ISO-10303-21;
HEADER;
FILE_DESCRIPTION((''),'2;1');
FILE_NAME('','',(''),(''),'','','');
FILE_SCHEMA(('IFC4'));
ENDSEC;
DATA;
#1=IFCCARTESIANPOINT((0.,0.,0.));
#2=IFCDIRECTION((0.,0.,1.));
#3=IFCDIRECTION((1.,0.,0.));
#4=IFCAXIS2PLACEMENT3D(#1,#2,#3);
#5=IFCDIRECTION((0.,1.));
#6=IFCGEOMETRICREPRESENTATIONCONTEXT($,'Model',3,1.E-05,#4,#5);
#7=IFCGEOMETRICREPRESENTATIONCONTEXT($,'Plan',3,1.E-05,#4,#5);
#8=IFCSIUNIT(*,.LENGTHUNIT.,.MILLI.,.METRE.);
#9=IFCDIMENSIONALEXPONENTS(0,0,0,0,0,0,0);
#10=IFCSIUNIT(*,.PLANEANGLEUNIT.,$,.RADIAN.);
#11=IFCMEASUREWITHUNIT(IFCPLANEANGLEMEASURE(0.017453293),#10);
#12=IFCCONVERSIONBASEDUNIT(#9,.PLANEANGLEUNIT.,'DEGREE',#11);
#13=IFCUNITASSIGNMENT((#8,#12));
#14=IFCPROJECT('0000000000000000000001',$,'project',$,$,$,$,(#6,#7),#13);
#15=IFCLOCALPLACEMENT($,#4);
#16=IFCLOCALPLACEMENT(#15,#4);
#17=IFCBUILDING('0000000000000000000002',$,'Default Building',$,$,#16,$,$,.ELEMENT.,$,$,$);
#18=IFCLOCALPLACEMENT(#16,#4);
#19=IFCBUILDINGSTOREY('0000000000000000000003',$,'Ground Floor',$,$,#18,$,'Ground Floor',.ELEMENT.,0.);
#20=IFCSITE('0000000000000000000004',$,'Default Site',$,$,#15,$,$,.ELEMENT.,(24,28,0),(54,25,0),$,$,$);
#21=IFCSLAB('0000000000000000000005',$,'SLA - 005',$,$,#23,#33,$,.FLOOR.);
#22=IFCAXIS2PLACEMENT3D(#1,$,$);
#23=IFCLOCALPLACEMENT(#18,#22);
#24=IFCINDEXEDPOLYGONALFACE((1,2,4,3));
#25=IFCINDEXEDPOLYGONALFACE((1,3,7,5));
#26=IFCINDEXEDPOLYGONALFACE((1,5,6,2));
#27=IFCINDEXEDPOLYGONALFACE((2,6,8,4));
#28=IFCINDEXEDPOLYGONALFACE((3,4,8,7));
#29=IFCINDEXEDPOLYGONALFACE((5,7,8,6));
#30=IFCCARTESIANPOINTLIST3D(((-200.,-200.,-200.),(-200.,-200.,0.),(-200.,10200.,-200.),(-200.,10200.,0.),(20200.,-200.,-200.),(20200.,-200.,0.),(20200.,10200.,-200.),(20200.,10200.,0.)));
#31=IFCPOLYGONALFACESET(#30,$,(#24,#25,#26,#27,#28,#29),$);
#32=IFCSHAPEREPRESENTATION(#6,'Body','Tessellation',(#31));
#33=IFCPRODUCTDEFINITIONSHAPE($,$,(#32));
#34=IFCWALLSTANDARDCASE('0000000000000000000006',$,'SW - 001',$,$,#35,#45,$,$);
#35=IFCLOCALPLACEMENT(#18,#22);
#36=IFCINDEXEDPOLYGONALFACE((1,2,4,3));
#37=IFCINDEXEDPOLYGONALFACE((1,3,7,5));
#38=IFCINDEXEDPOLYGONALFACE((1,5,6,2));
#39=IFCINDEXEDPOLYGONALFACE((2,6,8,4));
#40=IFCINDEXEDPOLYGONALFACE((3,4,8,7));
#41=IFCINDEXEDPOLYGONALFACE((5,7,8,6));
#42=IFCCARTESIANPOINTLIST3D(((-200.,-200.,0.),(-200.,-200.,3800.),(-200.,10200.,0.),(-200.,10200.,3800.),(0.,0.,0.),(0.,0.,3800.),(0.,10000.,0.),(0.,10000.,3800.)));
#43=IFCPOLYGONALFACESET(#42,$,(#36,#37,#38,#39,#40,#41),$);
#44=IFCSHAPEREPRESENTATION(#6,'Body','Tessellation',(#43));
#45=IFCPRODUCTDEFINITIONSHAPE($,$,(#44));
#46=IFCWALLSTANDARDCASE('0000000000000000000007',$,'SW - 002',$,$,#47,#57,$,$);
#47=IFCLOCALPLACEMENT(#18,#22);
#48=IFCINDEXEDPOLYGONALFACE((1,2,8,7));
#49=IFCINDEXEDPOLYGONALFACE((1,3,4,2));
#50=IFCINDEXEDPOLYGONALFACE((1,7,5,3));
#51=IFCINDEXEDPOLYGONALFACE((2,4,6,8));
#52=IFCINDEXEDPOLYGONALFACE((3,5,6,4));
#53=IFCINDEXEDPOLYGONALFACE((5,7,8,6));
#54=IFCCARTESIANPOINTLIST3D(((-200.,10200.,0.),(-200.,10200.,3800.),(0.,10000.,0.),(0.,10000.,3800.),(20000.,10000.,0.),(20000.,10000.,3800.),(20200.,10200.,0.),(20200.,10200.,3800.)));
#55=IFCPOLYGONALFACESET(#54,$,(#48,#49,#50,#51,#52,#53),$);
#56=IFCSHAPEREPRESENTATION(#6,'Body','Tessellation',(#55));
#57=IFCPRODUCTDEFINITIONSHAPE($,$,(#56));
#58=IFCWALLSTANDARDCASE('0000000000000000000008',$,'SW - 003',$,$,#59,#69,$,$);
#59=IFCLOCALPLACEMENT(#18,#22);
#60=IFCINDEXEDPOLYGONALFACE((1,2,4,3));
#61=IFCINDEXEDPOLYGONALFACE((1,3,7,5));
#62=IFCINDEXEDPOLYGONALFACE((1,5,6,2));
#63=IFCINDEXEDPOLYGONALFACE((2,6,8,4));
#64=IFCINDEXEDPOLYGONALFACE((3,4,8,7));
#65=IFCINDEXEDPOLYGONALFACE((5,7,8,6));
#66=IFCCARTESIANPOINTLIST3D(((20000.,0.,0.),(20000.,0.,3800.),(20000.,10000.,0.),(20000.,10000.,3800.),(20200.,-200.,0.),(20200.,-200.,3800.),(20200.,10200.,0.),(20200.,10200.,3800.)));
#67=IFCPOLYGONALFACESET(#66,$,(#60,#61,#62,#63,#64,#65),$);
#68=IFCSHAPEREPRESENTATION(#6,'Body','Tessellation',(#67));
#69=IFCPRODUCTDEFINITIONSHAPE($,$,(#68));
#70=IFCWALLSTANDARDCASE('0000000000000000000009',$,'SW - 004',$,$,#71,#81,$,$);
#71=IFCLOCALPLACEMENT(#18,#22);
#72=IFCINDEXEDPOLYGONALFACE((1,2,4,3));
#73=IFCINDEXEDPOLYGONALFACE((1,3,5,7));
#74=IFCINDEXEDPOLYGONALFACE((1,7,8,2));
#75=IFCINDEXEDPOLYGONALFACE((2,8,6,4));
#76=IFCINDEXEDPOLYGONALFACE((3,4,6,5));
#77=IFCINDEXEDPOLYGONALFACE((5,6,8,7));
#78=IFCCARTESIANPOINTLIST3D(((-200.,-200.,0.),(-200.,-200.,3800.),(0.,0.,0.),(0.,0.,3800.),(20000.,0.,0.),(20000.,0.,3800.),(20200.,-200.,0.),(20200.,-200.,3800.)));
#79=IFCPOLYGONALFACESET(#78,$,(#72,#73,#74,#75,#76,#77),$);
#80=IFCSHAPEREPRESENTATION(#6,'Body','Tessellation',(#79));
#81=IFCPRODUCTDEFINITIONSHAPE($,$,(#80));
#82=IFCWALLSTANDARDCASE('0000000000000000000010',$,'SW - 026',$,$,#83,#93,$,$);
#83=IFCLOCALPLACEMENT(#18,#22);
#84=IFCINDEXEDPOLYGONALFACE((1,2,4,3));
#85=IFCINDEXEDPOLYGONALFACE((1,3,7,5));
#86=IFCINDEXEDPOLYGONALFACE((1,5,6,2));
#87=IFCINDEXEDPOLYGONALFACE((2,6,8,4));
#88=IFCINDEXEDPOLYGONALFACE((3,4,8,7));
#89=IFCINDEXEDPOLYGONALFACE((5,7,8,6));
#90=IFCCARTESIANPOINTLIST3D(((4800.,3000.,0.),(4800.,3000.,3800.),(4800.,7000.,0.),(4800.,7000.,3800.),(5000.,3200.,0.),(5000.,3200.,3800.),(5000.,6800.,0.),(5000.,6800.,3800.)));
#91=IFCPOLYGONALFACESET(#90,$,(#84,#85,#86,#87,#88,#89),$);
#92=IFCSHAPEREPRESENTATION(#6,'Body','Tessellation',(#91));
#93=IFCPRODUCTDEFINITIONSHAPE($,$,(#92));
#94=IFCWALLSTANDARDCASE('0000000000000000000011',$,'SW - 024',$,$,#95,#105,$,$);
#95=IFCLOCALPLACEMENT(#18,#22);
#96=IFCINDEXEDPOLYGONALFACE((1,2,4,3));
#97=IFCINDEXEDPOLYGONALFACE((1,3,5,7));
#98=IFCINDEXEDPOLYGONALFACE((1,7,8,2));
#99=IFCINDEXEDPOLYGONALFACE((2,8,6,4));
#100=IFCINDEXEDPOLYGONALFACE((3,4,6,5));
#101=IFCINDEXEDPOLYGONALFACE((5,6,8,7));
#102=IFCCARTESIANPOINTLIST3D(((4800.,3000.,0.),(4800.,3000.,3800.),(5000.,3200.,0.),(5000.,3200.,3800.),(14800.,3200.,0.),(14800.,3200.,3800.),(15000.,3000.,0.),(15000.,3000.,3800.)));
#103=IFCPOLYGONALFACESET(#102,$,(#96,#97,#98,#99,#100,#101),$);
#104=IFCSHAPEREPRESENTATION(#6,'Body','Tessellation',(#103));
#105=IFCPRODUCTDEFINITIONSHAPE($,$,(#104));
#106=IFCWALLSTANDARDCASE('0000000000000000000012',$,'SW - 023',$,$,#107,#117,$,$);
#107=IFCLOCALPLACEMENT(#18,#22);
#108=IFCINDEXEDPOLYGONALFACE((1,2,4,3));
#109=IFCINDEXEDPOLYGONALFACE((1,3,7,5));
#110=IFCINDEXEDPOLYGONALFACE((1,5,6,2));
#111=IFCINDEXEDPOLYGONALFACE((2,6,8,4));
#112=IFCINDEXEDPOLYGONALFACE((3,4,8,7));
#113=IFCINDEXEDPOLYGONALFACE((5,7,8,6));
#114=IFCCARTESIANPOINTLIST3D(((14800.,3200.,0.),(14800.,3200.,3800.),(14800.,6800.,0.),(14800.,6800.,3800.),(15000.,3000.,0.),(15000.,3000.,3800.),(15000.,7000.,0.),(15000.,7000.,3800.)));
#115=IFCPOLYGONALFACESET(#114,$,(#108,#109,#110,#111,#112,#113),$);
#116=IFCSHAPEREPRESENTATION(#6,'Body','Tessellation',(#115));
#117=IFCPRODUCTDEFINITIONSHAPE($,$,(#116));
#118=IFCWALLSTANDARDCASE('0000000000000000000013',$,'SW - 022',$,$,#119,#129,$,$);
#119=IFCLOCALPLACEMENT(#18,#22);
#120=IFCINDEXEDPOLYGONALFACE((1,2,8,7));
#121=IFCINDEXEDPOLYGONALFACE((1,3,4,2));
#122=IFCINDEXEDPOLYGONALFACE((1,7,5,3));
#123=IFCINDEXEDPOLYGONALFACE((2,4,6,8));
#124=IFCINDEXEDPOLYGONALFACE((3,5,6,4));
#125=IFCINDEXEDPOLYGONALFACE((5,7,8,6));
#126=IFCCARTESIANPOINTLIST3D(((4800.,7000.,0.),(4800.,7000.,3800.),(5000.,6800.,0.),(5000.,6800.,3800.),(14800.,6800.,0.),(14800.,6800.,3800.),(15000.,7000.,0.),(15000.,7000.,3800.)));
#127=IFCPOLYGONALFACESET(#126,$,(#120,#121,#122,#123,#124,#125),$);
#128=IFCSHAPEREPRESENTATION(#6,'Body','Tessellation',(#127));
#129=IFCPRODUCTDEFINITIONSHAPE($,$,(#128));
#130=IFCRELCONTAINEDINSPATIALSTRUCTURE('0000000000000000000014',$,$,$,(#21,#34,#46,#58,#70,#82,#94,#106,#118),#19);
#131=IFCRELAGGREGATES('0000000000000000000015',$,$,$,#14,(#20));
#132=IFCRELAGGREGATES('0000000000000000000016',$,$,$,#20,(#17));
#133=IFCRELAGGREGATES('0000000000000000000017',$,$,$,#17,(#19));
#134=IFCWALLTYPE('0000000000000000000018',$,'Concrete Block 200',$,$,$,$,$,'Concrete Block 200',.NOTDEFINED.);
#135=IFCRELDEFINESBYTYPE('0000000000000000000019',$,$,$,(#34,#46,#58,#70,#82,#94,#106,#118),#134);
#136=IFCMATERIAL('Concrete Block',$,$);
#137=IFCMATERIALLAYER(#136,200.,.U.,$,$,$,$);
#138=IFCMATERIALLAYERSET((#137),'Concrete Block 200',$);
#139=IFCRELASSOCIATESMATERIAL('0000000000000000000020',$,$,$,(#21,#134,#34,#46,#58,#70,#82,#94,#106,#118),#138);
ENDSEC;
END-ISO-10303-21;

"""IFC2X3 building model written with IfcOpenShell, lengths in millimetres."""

from ifc_helpers import new_model, entity, si_unit, converted_unit, direction, frame, origin_with_axes, place, context, project, spatial, polyline, outline, extrude, material, layer, layer_set, layer_usage, type_object, element, save


model = new_model("IFC2X3")

# Units and contexts
model_context = context("Model", 3, precision=1e-05, world=origin_with_axes(), true_north=direction((0.0, 1.0)))
plan_context = context("Plan", 3, precision=1e-05, world=origin_with_axes(), true_north=direction((0.0, 1.0)))
ifc_project = project(units=[si_unit("LENGTHUNIT", "METRE", prefix="MILLI"), converted_unit("PLANEANGLEUNIT", "DEGREE", entity("IfcPlaneAngleMeasure", 0.017453293), si_unit("PLANEANGLEUNIT", "RADIAN"), dimensions=[0, 0, 0, 0, 0, 0, 0])], contexts=[model_context, plan_context])

# Site, building, storey
site_placement = place(None, origin_with_axes())
site = spatial("IfcSite", under=ifc_project, at=site_placement, Name="Default Site", CompositionType="ELEMENT", RefLatitude=(24, 28, 0), RefLongitude=(54, 25, 0))
building_placement = place(site_placement, origin_with_axes())
building = spatial("IfcBuilding", under=site, at=building_placement, Name="Default Building", CompositionType="ELEMENT")
storey_placement = place(building_placement, origin_with_axes())
storey = spatial("IfcBuildingStorey", under=building, at=storey_placement, Name="Ground Floor", LongName="Ground Floor", CompositionType="ELEMENT", Elevation=0.0)

# Slab
ifc_material = material(Name="Concrete Block")
ifc_layer = layer(ifc_material, 200.0, ventilated="UNKNOWN")
ifc_layer_set = layer_set([ifc_layer], Name="Concrete Block 200")
ifc_layer_usage_1 = layer_usage(ifc_layer_set, "AXIS3", "NEGATIVE", 200.0)
slab_placement = place(storey_placement, frame((-200.0, 10200.0, -200.0), z_axis=(0.0, 0.0, 1.0), x_axis=(1.0, 0.0, 0.0)))
element("IfcSlab", 1, at=slab_placement, inside=storey, material=ifc_layer_usage_1, Name="SLA - 005", PredefinedType="FLOOR", context=model_context, shape_type="SweptSolid", body=[
    extrude(outline(polyline([(0.0, 0.0), (20400.0, 0.0), (20400.0, -10400.0), (0.0, -10400.0), (0.0, 0.0)])), origin_with_axes(), (0.0, 0.0, 1.0), 200.0),
])

# Walls
ifc_layer_usage_2 = layer_usage(ifc_layer_set, "AXIS2", "POSITIVE", 0.0)
wall_type = type_object("IfcWallType", Name="Concrete Block 200", ElementType="Concrete Block 200", PredefinedType="NOTDEFINED", material=ifc_layer_set)
wall_1_placement = place(storey_placement, frame((0.0, 0.0, 0.0), z_axis=(0.0, 0.0, 1.0), x_axis=(0.0, 1.0, 0.0)))
element("IfcWallStandardCase", 2, at=wall_1_placement, inside=storey, type_object=wall_type, material=ifc_layer_usage_2, Name="SW - 001", context=model_context, shape_type="SweptSolid", body=[
    extrude(outline(polyline([(0.0, 0.0), (10000.0, 0.0), (10200.0, 200.0), (-200.0, 200.0), (0.0, 0.0)])), origin_with_axes(), (0.0, 0.0, 1.0), 3800.0),
])
ifc_layer_usage_3 = layer_usage(ifc_layer_set, "AXIS2", "POSITIVE", 0.0)
wall_2_placement = place(storey_placement, frame((0.0, 10000.0, 0.0), z_axis=(0.0, 0.0, 1.0), x_axis=(1.0, 0.0, 0.0)))
element("IfcWallStandardCase", 3, at=wall_2_placement, inside=storey, type_object=wall_type, material=ifc_layer_usage_3, Name="SW - 002", context=model_context, shape_type="SweptSolid", body=[
    extrude(outline(polyline([(0.0, 0.0), (20000.0, 0.0), (20200.0, 200.0), (-200.0, 200.0), (0.0, 0.0)])), origin_with_axes(), (0.0, 0.0, 1.0), 3800.0),
])
ifc_layer_usage_4 = layer_usage(ifc_layer_set, "AXIS2", "POSITIVE", 0.0)
wall_3_placement = place(storey_placement, frame((20000.0, 10000.0, 0.0), z_axis=(0.0, 0.0, 1.0), x_axis=(0.0, -1.0, 0.0)))
element("IfcWallStandardCase", 4, at=wall_3_placement, inside=storey, type_object=wall_type, material=ifc_layer_usage_4, Name="SW - 003", context=model_context, shape_type="SweptSolid", body=[
    extrude(outline(polyline([(0.0, 0.0), (10000.0, 0.0), (10200.0, 200.0), (-200.0, 200.0), (0.0, 0.0)])), origin_with_axes(), (0.0, 0.0, 1.0), 3800.0),
])
ifc_layer_usage_5 = layer_usage(ifc_layer_set, "AXIS2", "POSITIVE", 0.0)
wall_4_placement = place(storey_placement, frame((20000.0, 0.0, 0.0), z_axis=(0.0, 0.0, 1.0), x_axis=(-1.0, 0.0, 0.0)))
element("IfcWallStandardCase", 5, at=wall_4_placement, inside=storey, type_object=wall_type, material=ifc_layer_usage_5, Name="SW - 004", context=model_context, shape_type="SweptSolid", body=[
    extrude(outline(polyline([(0.0, 0.0), (20000.0, 0.0), (20200.0, 200.0), (-200.0, 200.0), (0.0, 0.0)])), origin_with_axes(), (0.0, 0.0, 1.0), 3800.0),
])
ifc_layer_usage_6 = layer_usage(ifc_layer_set, "AXIS2", "NEGATIVE", 0.0)
wall_5_placement = place(storey_placement, frame((5000.0, 6800.0, 0.0), z_axis=(0.0, 0.0, 1.0), x_axis=(0.0, -1.0, 0.0)))
element("IfcWallStandardCase", 6, at=wall_5_placement, inside=storey, type_object=wall_type, material=ifc_layer_usage_6, Name="SW - 026", context=model_context, shape_type="SweptSolid", body=[
    extrude(outline(polyline([(-200.0, -200.0), (3800.0, -200.0), (3600.0, 0.0), (0.0, 0.0), (-200.0, -200.0)])), origin_with_axes(), (0.0, 0.0, 1.0), 3800.0),
])
ifc_layer_usage_7 = layer_usage(ifc_layer_set, "AXIS2", "POSITIVE", 0.0)
wall_6_placement = place(storey_placement, frame((14800.0, 3200.0, 0.0), z_axis=(0.0, 0.0, 1.0), x_axis=(-1.0, 0.0, 0.0)))
element("IfcWallStandardCase", 7, at=wall_6_placement, inside=storey, type_object=wall_type, material=ifc_layer_usage_7, Name="SW - 024", context=model_context, shape_type="SweptSolid", body=[
    extrude(outline(polyline([(0.0, 0.0), (9800.0, 0.0), (10000.0, 200.0), (-200.0, 200.0), (0.0, 0.0)])), origin_with_axes(), (0.0, 0.0, 1.0), 3800.0),
])
ifc_layer_usage_8 = layer_usage(ifc_layer_set, "AXIS2", "POSITIVE", 0.0)
wall_7_placement = place(storey_placement, frame((14800.0, 6800.0, 0.0), z_axis=(0.0, 0.0, 1.0), x_axis=(0.0, -1.0, 0.0)))
element("IfcWallStandardCase", 8, at=wall_7_placement, inside=storey, type_object=wall_type, material=ifc_layer_usage_8, Name="SW - 023", context=model_context, shape_type="SweptSolid", body=[
    extrude(outline(polyline([(0.0, 0.0), (3600.0, 0.0), (3800.0, 200.0), (-200.0, 200.0), (0.0, 0.0)])), origin_with_axes(), (0.0, 0.0, 1.0), 3800.0),
])
ifc_layer_usage_9 = layer_usage(ifc_layer_set, "AXIS2", "POSITIVE", 0.0)
wall_8_placement = place(storey_placement, frame((5000.0, 6800.0, 0.0), z_axis=(0.0, 0.0, 1.0), x_axis=(1.0, 0.0, 0.0)))
element("IfcWallStandardCase", 9, at=wall_8_placement, inside=storey, type_object=wall_type, material=ifc_layer_usage_9, Name="SW - 022", context=model_context, shape_type="SweptSolid", body=[
    extrude(outline(polyline([(0.0, 0.0), (9800.0, 0.0), (10000.0, 200.0), (-200.0, 200.0), (0.0, 0.0)])), origin_with_axes(), (0.0, 0.0, 1.0), 3800.0),
])

save(model, "model.ifc")
